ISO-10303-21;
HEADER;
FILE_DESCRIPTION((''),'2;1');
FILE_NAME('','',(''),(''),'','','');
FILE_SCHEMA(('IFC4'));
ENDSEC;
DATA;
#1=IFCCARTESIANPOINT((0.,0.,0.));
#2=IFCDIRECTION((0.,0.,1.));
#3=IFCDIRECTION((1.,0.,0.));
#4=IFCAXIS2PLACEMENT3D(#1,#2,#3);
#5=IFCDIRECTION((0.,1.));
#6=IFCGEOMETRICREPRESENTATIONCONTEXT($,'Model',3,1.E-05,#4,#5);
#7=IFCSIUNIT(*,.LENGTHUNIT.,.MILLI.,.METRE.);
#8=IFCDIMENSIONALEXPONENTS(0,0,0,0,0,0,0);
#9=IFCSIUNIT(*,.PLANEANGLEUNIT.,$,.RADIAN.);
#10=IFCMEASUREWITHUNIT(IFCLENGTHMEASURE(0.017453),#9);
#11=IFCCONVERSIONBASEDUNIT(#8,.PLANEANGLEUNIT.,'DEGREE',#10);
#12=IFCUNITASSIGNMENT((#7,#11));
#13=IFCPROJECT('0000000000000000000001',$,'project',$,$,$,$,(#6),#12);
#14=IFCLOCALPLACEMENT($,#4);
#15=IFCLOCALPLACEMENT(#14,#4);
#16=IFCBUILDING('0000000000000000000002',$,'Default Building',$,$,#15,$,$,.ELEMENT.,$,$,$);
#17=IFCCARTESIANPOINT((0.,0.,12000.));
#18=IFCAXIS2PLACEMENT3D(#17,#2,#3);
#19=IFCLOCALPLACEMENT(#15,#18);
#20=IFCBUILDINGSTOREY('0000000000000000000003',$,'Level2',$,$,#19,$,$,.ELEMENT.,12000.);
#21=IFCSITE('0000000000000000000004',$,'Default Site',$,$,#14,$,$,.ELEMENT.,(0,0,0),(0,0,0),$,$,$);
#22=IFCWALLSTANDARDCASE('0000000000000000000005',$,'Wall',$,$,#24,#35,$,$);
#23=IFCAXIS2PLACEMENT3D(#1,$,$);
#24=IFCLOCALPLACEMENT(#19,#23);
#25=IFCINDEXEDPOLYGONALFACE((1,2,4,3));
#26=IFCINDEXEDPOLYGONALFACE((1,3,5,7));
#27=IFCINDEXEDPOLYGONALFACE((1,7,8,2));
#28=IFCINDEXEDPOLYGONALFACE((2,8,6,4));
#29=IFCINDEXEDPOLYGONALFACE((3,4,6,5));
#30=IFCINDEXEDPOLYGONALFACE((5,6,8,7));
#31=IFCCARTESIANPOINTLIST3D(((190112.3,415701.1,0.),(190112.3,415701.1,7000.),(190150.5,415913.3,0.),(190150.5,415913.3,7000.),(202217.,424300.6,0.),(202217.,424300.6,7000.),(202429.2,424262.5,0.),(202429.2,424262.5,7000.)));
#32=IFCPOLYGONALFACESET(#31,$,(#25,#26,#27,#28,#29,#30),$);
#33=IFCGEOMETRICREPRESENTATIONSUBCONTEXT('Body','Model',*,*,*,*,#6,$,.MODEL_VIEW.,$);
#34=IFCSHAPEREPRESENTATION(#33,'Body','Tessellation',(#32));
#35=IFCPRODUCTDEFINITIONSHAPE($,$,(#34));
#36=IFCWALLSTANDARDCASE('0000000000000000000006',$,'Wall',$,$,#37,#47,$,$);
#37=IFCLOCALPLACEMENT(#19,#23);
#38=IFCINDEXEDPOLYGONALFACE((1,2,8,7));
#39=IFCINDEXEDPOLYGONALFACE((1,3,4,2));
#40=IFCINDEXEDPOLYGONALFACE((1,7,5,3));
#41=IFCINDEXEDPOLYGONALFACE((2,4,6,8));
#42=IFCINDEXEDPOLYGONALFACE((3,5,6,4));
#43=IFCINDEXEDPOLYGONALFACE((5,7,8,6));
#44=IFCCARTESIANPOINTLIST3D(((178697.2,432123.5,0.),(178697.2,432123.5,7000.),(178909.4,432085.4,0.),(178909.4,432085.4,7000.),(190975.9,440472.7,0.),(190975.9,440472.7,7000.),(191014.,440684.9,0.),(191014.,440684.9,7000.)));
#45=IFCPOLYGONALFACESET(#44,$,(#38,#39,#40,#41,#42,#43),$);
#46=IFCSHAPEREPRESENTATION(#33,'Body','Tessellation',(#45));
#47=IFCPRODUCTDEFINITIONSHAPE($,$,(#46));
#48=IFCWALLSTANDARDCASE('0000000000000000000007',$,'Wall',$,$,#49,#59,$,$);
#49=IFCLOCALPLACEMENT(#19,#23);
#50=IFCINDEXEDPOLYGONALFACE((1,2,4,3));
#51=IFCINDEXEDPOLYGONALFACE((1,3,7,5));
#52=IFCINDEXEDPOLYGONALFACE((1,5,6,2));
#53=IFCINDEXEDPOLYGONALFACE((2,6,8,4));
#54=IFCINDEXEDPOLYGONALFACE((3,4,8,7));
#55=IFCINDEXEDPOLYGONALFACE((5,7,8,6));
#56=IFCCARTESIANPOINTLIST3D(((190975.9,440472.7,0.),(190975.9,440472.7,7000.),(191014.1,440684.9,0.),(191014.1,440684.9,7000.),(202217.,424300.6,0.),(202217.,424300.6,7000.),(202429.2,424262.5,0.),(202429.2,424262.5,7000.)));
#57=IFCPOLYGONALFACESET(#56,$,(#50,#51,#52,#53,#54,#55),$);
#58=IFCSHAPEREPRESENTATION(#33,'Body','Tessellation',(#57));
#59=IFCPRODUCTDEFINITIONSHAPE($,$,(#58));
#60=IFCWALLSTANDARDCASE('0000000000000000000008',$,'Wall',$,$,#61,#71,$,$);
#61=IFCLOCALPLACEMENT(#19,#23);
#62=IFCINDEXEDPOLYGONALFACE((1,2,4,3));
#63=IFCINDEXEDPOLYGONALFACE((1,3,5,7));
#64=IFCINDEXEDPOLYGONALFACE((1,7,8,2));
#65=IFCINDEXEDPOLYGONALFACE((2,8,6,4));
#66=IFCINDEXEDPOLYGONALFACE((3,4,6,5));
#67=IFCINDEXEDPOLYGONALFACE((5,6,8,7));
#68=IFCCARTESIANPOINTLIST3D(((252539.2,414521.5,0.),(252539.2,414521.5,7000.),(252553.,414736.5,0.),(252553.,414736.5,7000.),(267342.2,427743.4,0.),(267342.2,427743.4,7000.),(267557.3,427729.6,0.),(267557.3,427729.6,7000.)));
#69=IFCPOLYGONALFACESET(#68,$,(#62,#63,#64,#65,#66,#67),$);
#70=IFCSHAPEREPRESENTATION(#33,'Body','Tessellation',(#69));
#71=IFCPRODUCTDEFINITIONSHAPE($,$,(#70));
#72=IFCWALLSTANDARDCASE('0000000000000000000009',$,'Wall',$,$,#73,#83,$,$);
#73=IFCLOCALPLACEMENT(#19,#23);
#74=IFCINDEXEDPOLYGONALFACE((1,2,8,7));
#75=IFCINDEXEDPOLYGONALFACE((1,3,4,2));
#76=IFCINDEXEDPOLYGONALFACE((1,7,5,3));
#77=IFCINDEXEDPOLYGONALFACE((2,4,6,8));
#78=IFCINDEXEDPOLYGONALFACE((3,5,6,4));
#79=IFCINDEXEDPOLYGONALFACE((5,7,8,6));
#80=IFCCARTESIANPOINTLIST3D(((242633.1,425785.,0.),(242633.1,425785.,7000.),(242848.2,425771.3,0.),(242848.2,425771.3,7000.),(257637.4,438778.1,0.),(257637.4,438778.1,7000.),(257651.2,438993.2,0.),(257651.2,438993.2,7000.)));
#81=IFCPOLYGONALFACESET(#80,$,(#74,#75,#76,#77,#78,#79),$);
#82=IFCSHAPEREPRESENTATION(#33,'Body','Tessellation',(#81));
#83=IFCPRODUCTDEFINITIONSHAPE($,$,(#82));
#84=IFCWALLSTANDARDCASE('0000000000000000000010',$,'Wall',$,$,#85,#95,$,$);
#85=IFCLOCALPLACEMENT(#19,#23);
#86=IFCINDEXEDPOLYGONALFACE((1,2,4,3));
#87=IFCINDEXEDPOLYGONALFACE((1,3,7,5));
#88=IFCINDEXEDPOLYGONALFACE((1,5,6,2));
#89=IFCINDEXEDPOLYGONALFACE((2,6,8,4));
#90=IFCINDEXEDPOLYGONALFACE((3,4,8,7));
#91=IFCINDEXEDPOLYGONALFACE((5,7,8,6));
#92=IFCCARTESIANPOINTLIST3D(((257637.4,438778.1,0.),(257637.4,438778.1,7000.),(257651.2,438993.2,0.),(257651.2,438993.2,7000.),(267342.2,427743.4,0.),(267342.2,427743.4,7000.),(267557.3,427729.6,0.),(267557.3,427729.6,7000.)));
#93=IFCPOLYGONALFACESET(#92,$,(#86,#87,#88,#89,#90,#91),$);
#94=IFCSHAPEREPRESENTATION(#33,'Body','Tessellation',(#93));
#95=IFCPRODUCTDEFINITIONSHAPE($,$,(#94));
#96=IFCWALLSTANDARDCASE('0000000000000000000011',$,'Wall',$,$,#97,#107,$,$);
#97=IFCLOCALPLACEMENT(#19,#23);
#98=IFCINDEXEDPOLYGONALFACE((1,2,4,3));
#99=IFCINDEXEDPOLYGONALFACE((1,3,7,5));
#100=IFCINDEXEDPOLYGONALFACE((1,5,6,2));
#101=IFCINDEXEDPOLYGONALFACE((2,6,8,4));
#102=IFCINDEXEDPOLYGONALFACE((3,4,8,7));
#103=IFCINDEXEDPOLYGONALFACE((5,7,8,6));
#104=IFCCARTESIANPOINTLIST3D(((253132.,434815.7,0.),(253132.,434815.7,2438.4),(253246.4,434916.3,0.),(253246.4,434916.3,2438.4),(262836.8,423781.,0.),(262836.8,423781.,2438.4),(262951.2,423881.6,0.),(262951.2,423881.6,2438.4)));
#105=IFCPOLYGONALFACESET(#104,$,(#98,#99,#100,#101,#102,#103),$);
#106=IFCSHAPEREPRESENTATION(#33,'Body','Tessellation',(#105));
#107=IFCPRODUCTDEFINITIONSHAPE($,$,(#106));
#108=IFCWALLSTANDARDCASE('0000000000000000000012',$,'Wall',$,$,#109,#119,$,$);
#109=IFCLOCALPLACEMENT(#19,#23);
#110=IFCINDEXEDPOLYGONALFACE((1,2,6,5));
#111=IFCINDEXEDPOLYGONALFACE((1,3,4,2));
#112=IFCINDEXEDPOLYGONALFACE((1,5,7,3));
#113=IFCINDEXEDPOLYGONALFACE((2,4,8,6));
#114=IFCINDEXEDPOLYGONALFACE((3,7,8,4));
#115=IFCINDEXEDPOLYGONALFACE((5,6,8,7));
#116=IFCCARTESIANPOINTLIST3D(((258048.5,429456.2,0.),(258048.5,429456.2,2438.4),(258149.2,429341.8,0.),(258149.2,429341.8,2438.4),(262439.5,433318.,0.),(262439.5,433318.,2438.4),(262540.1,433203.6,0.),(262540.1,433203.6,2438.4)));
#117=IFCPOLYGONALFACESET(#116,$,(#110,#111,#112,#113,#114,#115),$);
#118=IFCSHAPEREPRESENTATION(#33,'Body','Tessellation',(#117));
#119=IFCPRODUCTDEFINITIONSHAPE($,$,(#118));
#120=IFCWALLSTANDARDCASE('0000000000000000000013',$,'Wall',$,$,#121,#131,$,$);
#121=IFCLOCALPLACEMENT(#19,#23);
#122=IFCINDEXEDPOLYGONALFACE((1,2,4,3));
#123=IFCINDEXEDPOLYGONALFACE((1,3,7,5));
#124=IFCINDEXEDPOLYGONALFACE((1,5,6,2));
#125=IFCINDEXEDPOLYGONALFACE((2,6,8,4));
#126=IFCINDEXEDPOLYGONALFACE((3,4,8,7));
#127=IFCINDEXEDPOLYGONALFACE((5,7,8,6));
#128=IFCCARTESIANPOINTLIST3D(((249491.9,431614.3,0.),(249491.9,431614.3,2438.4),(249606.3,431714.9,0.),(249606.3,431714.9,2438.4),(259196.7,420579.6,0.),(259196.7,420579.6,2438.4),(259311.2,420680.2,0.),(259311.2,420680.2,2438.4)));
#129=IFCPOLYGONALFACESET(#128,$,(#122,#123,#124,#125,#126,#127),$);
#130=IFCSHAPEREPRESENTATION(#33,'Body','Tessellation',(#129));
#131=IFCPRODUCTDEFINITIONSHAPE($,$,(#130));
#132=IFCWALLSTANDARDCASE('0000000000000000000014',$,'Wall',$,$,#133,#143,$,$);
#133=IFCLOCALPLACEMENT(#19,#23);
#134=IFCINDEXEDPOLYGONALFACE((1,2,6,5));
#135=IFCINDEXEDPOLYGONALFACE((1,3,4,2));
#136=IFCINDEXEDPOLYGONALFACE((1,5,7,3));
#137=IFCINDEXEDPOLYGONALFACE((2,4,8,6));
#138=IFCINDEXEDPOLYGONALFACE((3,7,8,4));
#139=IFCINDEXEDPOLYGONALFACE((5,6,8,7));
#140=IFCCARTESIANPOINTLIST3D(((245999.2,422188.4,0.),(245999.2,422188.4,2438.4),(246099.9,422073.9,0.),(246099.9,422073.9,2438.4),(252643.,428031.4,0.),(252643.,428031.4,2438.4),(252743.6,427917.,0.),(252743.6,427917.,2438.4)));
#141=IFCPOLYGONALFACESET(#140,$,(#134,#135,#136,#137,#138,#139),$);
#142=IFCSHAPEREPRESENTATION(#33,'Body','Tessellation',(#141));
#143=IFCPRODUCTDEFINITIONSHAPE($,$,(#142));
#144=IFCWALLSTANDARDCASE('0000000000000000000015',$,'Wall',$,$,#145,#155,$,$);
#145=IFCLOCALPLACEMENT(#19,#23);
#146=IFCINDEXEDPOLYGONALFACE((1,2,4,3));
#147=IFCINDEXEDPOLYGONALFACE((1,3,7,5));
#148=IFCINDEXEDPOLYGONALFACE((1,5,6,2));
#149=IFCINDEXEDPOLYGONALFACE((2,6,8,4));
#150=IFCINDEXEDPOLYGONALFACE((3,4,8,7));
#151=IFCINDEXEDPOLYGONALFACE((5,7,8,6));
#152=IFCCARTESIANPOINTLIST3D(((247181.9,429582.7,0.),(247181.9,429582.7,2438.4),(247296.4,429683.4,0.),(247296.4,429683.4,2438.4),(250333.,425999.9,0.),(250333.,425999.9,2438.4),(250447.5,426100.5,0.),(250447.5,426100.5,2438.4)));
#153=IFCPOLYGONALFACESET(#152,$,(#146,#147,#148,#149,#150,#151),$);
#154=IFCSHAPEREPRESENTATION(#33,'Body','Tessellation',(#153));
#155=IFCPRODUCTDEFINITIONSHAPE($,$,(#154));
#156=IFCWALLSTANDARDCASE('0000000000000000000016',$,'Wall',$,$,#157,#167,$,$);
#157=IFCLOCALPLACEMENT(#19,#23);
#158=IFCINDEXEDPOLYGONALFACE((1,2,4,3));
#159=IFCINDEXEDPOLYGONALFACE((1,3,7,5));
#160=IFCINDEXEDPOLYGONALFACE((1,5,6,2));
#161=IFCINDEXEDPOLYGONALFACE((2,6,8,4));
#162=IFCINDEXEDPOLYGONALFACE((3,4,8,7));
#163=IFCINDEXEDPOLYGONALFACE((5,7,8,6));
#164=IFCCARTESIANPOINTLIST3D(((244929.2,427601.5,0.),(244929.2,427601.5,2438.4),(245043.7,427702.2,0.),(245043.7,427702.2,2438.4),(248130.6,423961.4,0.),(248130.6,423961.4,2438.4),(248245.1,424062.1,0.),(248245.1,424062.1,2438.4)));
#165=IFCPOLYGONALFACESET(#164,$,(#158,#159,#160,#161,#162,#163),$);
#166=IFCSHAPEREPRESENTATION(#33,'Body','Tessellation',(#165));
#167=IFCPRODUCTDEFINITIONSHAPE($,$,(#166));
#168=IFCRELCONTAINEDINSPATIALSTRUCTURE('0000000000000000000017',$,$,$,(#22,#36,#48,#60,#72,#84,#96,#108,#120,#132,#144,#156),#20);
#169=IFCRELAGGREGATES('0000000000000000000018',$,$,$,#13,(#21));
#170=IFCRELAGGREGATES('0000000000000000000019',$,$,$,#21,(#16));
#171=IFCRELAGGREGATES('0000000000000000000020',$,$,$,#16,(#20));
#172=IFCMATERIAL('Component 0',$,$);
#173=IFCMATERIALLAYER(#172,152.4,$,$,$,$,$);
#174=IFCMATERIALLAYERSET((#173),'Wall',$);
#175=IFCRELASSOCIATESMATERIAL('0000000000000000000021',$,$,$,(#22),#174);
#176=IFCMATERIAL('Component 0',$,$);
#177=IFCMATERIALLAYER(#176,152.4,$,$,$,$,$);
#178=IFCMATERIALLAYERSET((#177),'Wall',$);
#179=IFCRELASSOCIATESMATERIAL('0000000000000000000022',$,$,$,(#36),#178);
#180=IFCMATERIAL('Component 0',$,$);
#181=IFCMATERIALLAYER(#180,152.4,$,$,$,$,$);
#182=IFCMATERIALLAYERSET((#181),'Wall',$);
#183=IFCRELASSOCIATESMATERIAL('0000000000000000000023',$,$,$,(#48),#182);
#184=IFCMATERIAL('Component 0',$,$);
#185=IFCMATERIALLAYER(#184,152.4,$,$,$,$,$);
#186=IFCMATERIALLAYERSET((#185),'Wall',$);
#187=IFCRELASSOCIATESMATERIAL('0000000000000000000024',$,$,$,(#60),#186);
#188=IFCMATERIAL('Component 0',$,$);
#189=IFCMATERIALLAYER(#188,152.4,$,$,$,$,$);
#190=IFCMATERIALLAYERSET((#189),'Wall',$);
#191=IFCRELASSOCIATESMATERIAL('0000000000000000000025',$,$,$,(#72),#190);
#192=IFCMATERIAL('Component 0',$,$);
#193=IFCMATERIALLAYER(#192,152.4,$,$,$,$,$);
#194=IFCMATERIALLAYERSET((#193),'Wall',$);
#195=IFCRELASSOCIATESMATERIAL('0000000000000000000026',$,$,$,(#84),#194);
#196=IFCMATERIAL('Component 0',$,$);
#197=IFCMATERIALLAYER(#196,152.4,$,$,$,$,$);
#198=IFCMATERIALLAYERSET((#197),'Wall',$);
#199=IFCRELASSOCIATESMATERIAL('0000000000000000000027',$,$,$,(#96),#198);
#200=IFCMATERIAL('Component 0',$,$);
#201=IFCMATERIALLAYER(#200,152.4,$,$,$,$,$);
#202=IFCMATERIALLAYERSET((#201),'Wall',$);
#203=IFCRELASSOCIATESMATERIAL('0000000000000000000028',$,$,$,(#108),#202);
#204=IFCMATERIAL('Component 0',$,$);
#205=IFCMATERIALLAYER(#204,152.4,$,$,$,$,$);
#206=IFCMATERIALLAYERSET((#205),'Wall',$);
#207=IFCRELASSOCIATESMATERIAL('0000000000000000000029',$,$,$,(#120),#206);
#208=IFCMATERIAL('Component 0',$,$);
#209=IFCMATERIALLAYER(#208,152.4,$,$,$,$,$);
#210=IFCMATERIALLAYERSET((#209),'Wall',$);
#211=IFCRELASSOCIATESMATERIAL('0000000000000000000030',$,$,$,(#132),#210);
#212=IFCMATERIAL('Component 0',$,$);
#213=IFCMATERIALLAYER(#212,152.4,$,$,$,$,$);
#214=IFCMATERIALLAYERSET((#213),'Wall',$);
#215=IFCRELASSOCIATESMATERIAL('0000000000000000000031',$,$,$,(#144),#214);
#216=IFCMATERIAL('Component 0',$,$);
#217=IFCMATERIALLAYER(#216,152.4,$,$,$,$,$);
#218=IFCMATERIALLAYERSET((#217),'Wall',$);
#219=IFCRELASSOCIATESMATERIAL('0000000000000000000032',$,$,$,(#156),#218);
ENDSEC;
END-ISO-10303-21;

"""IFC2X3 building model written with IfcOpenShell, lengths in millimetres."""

from ifc_helpers import new_model, entity, si_unit, converted_unit, direction, frame, origin_with_axes, place, context, subcontext, project, spatial, polyline, outline, extrude, material, layer, layer_set, layer_usage, element, save


model = new_model("IFC2X3")

# Units and contexts
model_context = context("Model", 3, precision=1e-05, world=origin_with_axes(), true_north=direction((0.0, 1.0)))
body_context = subcontext(model_context, "Body", "Model", "MODEL_VIEW")
ifc_project = project(units=[si_unit("LENGTHUNIT", "METRE", prefix="MILLI"), converted_unit("PLANEANGLEUNIT", "DEGREE", entity("IfcLengthMeasure", 0.017453), si_unit("PLANEANGLEUNIT", "RADIAN"), dimensions=[0, 0, 0, 0, 0, 0, 0])], contexts=[model_context])

# Site, building, storey
site_placement = place(None, origin_with_axes())
site = spatial("IfcSite", under=ifc_project, at=site_placement, Name="Default Site", CompositionType="ELEMENT", RefLatitude=(0, 0, 0), RefLongitude=(0, 0, 0))
building_placement = place(site_placement, origin_with_axes())
building = spatial("IfcBuilding", under=site, at=building_placement, Name="Default Building", CompositionType="ELEMENT")
storey_placement = place(building_placement, frame((0.0, 0.0, 12000.0), z_axis=(0.0, 0.0, 1.0), x_axis=(1.0, 0.0, 0.0)))
storey = spatial("IfcBuildingStorey", under=building, at=storey_placement, Name="Level2", CompositionType="ELEMENT", Elevation=12000.0)

# Walls
ifc_material_1 = material(Name="Component 0")
ifc_layer_1 = layer(ifc_material_1, 152.4)
ifc_layer_set_1 = layer_set([ifc_layer_1], Name="Wall")
ifc_layer_usage_1 = layer_usage(ifc_layer_set_1, "AXIS2", "POSITIVE", -76.2)
wall_1_placement = place(storey_placement, frame((202323.1, 424281.5, 0.0), z_axis=(0.0, 0.0, 1.0), x_axis=(-0.82112, -0.570755, 0.0)))
element("IfcWallStandardCase", 1, at=wall_1_placement, inside=storey, material=ifc_layer_usage_1, Name="Wall", context=body_context, shape_type="SweptSolid", body=[
    extrude(outline(polyline([(76.2, -76.2), (-76.2, 76.2), (14923.8, 76.2), (14771.4, -76.2), (76.2, -76.2)])), origin_with_axes(), (0.0, 0.0, 1.0), 7000.0),
])
ifc_material_2 = material(Name="Component 0")
ifc_layer_2 = layer(ifc_material_2, 152.4)
ifc_layer_set_2 = layer_set([ifc_layer_2], Name="Wall")
ifc_layer_usage_2 = layer_usage(ifc_layer_set_2, "AXIS2", "POSITIVE", -76.2)
wall_2_placement = place(storey_placement, frame((178803.3, 432104.5, 0.0), z_axis=(0.0, 0.0, 1.0), x_axis=(0.82112, 0.570755, 0.0)))
element("IfcWallStandardCase", 2, at=wall_2_placement, inside=storey, material=ifc_layer_usage_2, Name="Wall", context=body_context, shape_type="SweptSolid", body=[
    extrude(outline(polyline([(76.2, -76.2), (-76.2, 76.2), (14923.8, 76.2), (14771.4, -76.2), (76.2, -76.2)])), origin_with_axes(), (0.0, 0.0, 1.0), 7000.0),
])
ifc_material_3 = material(Name="Component 0")
ifc_layer_3 = layer(ifc_material_3, 152.4)
ifc_layer_set_3 = layer_set([ifc_layer_3], Name="Wall")
ifc_layer_usage_3 = layer_usage(ifc_layer_set_3, "AXIS2", "POSITIVE", -76.2)
wall_3_placement = place(storey_placement, frame((190995.0, 440578.8, 0.0), z_axis=(0.0, 0.0, 1.0), x_axis=(0.570755, -0.82112, 0.0)))
element("IfcWallStandardCase", 3, at=wall_3_placement, inside=storey, material=ifc_layer_usage_3, Name="Wall", context=body_context, shape_type="SweptSolid", body=[
    extrude(outline(polyline([(76.2, -76.2), (-76.2, 76.2), (19923.8, 76.2), (19771.4, -76.2), (76.2, -76.2)])), origin_with_axes(), (0.0, 0.0, 1.0), 7000.0),
])
ifc_material_4 = material(Name="Component 0")
ifc_layer_4 = layer(ifc_material_4, 152.4)
ifc_layer_set_4 = layer_set([ifc_layer_4], Name="Wall")
ifc_layer_usage_4 = layer_usage(ifc_layer_set_4, "AXIS2", "POSITIVE", -76.2)
wall_4_placement = place(storey_placement, frame((267449.8, 427736.5, 0.0), z_axis=(0.0, 0.0, 1.0), x_axis=(-0.750906, -0.660409, 0.0)))
element("IfcWallStandardCase", 4, at=wall_4_placement, inside=storey, material=ifc_layer_usage_4, Name="Wall", context=body_context, shape_type="SweptSolid", body=[
    extrude(outline(polyline([(76.2, -76.2), (-76.2, 76.2), (19923.8, 76.2), (19771.4, -76.2), (76.2, -76.2)])), origin_with_axes(), (0.0, 0.0, 1.0), 7000.0),
])
ifc_material_5 = material(Name="Component 0")
ifc_layer_5 = layer(ifc_material_5, 152.4)
ifc_layer_set_5 = layer_set([ifc_layer_5], Name="Wall")
ifc_layer_usage_5 = layer_usage(ifc_layer_set_5, "AXIS2", "POSITIVE", -76.2)
wall_5_placement = place(storey_placement, frame((242740.6, 425778.2, 0.0), z_axis=(0.0, 0.0, 1.0), x_axis=(0.750906, 0.660409, 0.0)))
element("IfcWallStandardCase", 5, at=wall_5_placement, inside=storey, material=ifc_layer_usage_5, Name="Wall", context=body_context, shape_type="SweptSolid", body=[
    extrude(outline(polyline([(76.2, -76.2), (-76.2, 76.2), (19923.8, 76.2), (19771.4, -76.2), (76.2, -76.2)])), origin_with_axes(), (0.0, 0.0, 1.0), 7000.0),
])
ifc_material_6 = material(Name="Component 0")
ifc_layer_6 = layer(ifc_material_6, 152.4)
ifc_layer_set_6 = layer_set([ifc_layer_6], Name="Wall")
ifc_layer_usage_6 = layer_usage(ifc_layer_set_6, "AXIS2", "POSITIVE", -76.2)
wall_6_placement = place(storey_placement, frame((257644.3, 438885.7, 0.0), z_axis=(0.0, 0.0, 1.0), x_axis=(0.660409, -0.750906, 0.0)))
element("IfcWallStandardCase", 6, at=wall_6_placement, inside=storey, material=ifc_layer_usage_6, Name="Wall", context=body_context, shape_type="SweptSolid", body=[
    extrude(outline(polyline([(76.2, -76.2), (-76.2, 76.2), (14923.8, 76.2), (14771.4, -76.2), (76.2, -76.2)])), origin_with_axes(), (0.0, 0.0, 1.0), 7000.0),
])
ifc_material_7 = material(Name="Component 0")
ifc_layer_7 = layer(ifc_material_7, 152.4)
ifc_layer_set_7 = layer_set([ifc_layer_7], Name="Wall")
ifc_layer_usage_7 = layer_usage(ifc_layer_set_7, "AXIS2", "POSITIVE", -76.2)
wall_7_placement = place(storey_placement, frame((253138.9, 434923.2, 0.0), z_axis=(0.0, 0.0, 1.0), x_axis=(0.660409, -0.750906, 0.0)))
element("IfcWallStandardCase", 7, at=wall_7_placement, inside=storey, material=ifc_layer_usage_7, Name="Wall", context=body_context, shape_type="SweptSolid", body=[
    extrude(outline(polyline([(76.2, -76.2), (76.2, 76.2), (14771.4, 76.2), (14771.4, -76.2), (76.2, -76.2)])), origin_with_axes(), (0.0, 0.0, 1.0), 2438.4),
])
ifc_material_8 = material(Name="Component 0")
ifc_layer_8 = layer(ifc_material_8, 152.4)
ifc_layer_set_8 = layer_set([ifc_layer_8], Name="Wall")
ifc_layer_usage_8 = layer_usage(ifc_layer_set_8, "AXIS2", "POSITIVE", -76.2)
wall_8_placement = place(storey_placement, frame((258041.6, 429348.7, 0.0), z_axis=(0.0, 0.0, 1.0), x_axis=(0.750906, 0.660409, 0.0)))
element("IfcWallStandardCase", 8, at=wall_8_placement, inside=storey, material=ifc_layer_usage_8, Name="Wall", context=body_context, shape_type="SweptSolid", body=[
    extrude(outline(polyline([(76.2, -76.2), (76.2, 76.2), (5923.8, 76.2), (5923.8, -76.2), (76.2, -76.2)])), origin_with_axes(), (0.0, 0.0, 1.0), 2438.4),
])
ifc_material_9 = material(Name="Component 0")
ifc_layer_9 = layer(ifc_material_9, 152.4)
ifc_layer_set_9 = layer_set([ifc_layer_9], Name="Wall")
ifc_layer_usage_9 = layer_usage(ifc_layer_set_9, "AXIS2", "POSITIVE", -76.2)
wall_9_placement = place(storey_placement, frame((259304.3, 420572.7, 0.0), z_axis=(0.0, 0.0, 1.0), x_axis=(-0.660409, 0.750906, 0.0)))
element("IfcWallStandardCase", 9, at=wall_9_placement, inside=storey, material=ifc_layer_usage_9, Name="Wall", context=body_context, shape_type="SweptSolid", body=[
    extrude(outline(polyline([(76.2, -76.2), (76.2, 76.2), (14771.4, 76.2), (14771.4, -76.2), (76.2, -76.2)])), origin_with_axes(), (0.0, 0.0, 1.0), 2438.4),
])
ifc_material_10 = material(Name="Component 0")
ifc_layer_10 = layer(ifc_material_10, 152.4)
ifc_layer_set_10 = layer_set([ifc_layer_10], Name="Wall")
ifc_layer_usage_10 = layer_usage(ifc_layer_set_10, "AXIS2", "POSITIVE", -76.2)
wall_10_placement = place(storey_placement, frame((245992.3, 422080.8, 0.0), z_axis=(0.0, 0.0, 1.0), x_axis=(0.750906, 0.660409, 0.0)))
element("IfcWallStandardCase", 10, at=wall_10_placement, inside=storey, material=ifc_layer_usage_10, Name="Wall", context=body_context, shape_type="SweptSolid", body=[
    extrude(outline(polyline([(76.2, -76.2), (76.2, 76.2), (8923.8, 76.2), (8923.8, -76.2), (76.2, -76.2)])), origin_with_axes(), (0.0, 0.0, 1.0), 2438.4),
])
ifc_material_11 = material(Name="Component 0")
ifc_layer_11 = layer(ifc_material_11, 152.4)
ifc_layer_set_11 = layer_set([ifc_layer_11], Name="Wall")
ifc_layer_usage_11 = layer_usage(ifc_layer_set_11, "AXIS2", "POSITIVE", -76.2)
wall_11_placement = place(storey_placement, frame((247188.8, 429690.3, 0.0), z_axis=(0.0, 0.0, 1.0), x_axis=(0.660409, -0.750906, 0.0)))
element("IfcWallStandardCase", 11, at=wall_11_placement, inside=storey, material=ifc_layer_usage_11, Name="Wall", context=body_context, shape_type="SweptSolid", body=[
    extrude(outline(polyline([(76.2, -76.2), (76.2, 76.2), (4847.6, 76.2), (4847.6, -76.2), (76.2, -76.2)])), origin_with_axes(), (0.0, 0.0, 1.0), 2438.4),
])
ifc_material_12 = material(Name="Component 0")
ifc_layer_12 = layer(ifc_material_12, 152.4)
ifc_layer_set_12 = layer_set([ifc_layer_12], Name="Wall")
ifc_layer_usage_12 = layer_usage(ifc_layer_set_12, "AXIS2", "POSITIVE", -76.2)
wall_12_placement = place(storey_placement, frame((244936.1, 427709.1, 0.0), z_axis=(0.0, 0.0, 1.0), x_axis=(0.660409, -0.750906, 0.0)))
element("IfcWallStandardCase", 12, at=wall_12_placement, inside=storey, material=ifc_layer_usage_12, Name="Wall", context=body_context, shape_type="SweptSolid", body=[
    extrude(outline(polyline([(76.2, -76.2), (76.2, 76.2), (4923.8, 76.2), (4923.8, -76.2), (76.2, -76.2)])), origin_with_axes(), (0.0, 0.0, 1.0), 2438.4),
])

save(model, "model.ifc")
